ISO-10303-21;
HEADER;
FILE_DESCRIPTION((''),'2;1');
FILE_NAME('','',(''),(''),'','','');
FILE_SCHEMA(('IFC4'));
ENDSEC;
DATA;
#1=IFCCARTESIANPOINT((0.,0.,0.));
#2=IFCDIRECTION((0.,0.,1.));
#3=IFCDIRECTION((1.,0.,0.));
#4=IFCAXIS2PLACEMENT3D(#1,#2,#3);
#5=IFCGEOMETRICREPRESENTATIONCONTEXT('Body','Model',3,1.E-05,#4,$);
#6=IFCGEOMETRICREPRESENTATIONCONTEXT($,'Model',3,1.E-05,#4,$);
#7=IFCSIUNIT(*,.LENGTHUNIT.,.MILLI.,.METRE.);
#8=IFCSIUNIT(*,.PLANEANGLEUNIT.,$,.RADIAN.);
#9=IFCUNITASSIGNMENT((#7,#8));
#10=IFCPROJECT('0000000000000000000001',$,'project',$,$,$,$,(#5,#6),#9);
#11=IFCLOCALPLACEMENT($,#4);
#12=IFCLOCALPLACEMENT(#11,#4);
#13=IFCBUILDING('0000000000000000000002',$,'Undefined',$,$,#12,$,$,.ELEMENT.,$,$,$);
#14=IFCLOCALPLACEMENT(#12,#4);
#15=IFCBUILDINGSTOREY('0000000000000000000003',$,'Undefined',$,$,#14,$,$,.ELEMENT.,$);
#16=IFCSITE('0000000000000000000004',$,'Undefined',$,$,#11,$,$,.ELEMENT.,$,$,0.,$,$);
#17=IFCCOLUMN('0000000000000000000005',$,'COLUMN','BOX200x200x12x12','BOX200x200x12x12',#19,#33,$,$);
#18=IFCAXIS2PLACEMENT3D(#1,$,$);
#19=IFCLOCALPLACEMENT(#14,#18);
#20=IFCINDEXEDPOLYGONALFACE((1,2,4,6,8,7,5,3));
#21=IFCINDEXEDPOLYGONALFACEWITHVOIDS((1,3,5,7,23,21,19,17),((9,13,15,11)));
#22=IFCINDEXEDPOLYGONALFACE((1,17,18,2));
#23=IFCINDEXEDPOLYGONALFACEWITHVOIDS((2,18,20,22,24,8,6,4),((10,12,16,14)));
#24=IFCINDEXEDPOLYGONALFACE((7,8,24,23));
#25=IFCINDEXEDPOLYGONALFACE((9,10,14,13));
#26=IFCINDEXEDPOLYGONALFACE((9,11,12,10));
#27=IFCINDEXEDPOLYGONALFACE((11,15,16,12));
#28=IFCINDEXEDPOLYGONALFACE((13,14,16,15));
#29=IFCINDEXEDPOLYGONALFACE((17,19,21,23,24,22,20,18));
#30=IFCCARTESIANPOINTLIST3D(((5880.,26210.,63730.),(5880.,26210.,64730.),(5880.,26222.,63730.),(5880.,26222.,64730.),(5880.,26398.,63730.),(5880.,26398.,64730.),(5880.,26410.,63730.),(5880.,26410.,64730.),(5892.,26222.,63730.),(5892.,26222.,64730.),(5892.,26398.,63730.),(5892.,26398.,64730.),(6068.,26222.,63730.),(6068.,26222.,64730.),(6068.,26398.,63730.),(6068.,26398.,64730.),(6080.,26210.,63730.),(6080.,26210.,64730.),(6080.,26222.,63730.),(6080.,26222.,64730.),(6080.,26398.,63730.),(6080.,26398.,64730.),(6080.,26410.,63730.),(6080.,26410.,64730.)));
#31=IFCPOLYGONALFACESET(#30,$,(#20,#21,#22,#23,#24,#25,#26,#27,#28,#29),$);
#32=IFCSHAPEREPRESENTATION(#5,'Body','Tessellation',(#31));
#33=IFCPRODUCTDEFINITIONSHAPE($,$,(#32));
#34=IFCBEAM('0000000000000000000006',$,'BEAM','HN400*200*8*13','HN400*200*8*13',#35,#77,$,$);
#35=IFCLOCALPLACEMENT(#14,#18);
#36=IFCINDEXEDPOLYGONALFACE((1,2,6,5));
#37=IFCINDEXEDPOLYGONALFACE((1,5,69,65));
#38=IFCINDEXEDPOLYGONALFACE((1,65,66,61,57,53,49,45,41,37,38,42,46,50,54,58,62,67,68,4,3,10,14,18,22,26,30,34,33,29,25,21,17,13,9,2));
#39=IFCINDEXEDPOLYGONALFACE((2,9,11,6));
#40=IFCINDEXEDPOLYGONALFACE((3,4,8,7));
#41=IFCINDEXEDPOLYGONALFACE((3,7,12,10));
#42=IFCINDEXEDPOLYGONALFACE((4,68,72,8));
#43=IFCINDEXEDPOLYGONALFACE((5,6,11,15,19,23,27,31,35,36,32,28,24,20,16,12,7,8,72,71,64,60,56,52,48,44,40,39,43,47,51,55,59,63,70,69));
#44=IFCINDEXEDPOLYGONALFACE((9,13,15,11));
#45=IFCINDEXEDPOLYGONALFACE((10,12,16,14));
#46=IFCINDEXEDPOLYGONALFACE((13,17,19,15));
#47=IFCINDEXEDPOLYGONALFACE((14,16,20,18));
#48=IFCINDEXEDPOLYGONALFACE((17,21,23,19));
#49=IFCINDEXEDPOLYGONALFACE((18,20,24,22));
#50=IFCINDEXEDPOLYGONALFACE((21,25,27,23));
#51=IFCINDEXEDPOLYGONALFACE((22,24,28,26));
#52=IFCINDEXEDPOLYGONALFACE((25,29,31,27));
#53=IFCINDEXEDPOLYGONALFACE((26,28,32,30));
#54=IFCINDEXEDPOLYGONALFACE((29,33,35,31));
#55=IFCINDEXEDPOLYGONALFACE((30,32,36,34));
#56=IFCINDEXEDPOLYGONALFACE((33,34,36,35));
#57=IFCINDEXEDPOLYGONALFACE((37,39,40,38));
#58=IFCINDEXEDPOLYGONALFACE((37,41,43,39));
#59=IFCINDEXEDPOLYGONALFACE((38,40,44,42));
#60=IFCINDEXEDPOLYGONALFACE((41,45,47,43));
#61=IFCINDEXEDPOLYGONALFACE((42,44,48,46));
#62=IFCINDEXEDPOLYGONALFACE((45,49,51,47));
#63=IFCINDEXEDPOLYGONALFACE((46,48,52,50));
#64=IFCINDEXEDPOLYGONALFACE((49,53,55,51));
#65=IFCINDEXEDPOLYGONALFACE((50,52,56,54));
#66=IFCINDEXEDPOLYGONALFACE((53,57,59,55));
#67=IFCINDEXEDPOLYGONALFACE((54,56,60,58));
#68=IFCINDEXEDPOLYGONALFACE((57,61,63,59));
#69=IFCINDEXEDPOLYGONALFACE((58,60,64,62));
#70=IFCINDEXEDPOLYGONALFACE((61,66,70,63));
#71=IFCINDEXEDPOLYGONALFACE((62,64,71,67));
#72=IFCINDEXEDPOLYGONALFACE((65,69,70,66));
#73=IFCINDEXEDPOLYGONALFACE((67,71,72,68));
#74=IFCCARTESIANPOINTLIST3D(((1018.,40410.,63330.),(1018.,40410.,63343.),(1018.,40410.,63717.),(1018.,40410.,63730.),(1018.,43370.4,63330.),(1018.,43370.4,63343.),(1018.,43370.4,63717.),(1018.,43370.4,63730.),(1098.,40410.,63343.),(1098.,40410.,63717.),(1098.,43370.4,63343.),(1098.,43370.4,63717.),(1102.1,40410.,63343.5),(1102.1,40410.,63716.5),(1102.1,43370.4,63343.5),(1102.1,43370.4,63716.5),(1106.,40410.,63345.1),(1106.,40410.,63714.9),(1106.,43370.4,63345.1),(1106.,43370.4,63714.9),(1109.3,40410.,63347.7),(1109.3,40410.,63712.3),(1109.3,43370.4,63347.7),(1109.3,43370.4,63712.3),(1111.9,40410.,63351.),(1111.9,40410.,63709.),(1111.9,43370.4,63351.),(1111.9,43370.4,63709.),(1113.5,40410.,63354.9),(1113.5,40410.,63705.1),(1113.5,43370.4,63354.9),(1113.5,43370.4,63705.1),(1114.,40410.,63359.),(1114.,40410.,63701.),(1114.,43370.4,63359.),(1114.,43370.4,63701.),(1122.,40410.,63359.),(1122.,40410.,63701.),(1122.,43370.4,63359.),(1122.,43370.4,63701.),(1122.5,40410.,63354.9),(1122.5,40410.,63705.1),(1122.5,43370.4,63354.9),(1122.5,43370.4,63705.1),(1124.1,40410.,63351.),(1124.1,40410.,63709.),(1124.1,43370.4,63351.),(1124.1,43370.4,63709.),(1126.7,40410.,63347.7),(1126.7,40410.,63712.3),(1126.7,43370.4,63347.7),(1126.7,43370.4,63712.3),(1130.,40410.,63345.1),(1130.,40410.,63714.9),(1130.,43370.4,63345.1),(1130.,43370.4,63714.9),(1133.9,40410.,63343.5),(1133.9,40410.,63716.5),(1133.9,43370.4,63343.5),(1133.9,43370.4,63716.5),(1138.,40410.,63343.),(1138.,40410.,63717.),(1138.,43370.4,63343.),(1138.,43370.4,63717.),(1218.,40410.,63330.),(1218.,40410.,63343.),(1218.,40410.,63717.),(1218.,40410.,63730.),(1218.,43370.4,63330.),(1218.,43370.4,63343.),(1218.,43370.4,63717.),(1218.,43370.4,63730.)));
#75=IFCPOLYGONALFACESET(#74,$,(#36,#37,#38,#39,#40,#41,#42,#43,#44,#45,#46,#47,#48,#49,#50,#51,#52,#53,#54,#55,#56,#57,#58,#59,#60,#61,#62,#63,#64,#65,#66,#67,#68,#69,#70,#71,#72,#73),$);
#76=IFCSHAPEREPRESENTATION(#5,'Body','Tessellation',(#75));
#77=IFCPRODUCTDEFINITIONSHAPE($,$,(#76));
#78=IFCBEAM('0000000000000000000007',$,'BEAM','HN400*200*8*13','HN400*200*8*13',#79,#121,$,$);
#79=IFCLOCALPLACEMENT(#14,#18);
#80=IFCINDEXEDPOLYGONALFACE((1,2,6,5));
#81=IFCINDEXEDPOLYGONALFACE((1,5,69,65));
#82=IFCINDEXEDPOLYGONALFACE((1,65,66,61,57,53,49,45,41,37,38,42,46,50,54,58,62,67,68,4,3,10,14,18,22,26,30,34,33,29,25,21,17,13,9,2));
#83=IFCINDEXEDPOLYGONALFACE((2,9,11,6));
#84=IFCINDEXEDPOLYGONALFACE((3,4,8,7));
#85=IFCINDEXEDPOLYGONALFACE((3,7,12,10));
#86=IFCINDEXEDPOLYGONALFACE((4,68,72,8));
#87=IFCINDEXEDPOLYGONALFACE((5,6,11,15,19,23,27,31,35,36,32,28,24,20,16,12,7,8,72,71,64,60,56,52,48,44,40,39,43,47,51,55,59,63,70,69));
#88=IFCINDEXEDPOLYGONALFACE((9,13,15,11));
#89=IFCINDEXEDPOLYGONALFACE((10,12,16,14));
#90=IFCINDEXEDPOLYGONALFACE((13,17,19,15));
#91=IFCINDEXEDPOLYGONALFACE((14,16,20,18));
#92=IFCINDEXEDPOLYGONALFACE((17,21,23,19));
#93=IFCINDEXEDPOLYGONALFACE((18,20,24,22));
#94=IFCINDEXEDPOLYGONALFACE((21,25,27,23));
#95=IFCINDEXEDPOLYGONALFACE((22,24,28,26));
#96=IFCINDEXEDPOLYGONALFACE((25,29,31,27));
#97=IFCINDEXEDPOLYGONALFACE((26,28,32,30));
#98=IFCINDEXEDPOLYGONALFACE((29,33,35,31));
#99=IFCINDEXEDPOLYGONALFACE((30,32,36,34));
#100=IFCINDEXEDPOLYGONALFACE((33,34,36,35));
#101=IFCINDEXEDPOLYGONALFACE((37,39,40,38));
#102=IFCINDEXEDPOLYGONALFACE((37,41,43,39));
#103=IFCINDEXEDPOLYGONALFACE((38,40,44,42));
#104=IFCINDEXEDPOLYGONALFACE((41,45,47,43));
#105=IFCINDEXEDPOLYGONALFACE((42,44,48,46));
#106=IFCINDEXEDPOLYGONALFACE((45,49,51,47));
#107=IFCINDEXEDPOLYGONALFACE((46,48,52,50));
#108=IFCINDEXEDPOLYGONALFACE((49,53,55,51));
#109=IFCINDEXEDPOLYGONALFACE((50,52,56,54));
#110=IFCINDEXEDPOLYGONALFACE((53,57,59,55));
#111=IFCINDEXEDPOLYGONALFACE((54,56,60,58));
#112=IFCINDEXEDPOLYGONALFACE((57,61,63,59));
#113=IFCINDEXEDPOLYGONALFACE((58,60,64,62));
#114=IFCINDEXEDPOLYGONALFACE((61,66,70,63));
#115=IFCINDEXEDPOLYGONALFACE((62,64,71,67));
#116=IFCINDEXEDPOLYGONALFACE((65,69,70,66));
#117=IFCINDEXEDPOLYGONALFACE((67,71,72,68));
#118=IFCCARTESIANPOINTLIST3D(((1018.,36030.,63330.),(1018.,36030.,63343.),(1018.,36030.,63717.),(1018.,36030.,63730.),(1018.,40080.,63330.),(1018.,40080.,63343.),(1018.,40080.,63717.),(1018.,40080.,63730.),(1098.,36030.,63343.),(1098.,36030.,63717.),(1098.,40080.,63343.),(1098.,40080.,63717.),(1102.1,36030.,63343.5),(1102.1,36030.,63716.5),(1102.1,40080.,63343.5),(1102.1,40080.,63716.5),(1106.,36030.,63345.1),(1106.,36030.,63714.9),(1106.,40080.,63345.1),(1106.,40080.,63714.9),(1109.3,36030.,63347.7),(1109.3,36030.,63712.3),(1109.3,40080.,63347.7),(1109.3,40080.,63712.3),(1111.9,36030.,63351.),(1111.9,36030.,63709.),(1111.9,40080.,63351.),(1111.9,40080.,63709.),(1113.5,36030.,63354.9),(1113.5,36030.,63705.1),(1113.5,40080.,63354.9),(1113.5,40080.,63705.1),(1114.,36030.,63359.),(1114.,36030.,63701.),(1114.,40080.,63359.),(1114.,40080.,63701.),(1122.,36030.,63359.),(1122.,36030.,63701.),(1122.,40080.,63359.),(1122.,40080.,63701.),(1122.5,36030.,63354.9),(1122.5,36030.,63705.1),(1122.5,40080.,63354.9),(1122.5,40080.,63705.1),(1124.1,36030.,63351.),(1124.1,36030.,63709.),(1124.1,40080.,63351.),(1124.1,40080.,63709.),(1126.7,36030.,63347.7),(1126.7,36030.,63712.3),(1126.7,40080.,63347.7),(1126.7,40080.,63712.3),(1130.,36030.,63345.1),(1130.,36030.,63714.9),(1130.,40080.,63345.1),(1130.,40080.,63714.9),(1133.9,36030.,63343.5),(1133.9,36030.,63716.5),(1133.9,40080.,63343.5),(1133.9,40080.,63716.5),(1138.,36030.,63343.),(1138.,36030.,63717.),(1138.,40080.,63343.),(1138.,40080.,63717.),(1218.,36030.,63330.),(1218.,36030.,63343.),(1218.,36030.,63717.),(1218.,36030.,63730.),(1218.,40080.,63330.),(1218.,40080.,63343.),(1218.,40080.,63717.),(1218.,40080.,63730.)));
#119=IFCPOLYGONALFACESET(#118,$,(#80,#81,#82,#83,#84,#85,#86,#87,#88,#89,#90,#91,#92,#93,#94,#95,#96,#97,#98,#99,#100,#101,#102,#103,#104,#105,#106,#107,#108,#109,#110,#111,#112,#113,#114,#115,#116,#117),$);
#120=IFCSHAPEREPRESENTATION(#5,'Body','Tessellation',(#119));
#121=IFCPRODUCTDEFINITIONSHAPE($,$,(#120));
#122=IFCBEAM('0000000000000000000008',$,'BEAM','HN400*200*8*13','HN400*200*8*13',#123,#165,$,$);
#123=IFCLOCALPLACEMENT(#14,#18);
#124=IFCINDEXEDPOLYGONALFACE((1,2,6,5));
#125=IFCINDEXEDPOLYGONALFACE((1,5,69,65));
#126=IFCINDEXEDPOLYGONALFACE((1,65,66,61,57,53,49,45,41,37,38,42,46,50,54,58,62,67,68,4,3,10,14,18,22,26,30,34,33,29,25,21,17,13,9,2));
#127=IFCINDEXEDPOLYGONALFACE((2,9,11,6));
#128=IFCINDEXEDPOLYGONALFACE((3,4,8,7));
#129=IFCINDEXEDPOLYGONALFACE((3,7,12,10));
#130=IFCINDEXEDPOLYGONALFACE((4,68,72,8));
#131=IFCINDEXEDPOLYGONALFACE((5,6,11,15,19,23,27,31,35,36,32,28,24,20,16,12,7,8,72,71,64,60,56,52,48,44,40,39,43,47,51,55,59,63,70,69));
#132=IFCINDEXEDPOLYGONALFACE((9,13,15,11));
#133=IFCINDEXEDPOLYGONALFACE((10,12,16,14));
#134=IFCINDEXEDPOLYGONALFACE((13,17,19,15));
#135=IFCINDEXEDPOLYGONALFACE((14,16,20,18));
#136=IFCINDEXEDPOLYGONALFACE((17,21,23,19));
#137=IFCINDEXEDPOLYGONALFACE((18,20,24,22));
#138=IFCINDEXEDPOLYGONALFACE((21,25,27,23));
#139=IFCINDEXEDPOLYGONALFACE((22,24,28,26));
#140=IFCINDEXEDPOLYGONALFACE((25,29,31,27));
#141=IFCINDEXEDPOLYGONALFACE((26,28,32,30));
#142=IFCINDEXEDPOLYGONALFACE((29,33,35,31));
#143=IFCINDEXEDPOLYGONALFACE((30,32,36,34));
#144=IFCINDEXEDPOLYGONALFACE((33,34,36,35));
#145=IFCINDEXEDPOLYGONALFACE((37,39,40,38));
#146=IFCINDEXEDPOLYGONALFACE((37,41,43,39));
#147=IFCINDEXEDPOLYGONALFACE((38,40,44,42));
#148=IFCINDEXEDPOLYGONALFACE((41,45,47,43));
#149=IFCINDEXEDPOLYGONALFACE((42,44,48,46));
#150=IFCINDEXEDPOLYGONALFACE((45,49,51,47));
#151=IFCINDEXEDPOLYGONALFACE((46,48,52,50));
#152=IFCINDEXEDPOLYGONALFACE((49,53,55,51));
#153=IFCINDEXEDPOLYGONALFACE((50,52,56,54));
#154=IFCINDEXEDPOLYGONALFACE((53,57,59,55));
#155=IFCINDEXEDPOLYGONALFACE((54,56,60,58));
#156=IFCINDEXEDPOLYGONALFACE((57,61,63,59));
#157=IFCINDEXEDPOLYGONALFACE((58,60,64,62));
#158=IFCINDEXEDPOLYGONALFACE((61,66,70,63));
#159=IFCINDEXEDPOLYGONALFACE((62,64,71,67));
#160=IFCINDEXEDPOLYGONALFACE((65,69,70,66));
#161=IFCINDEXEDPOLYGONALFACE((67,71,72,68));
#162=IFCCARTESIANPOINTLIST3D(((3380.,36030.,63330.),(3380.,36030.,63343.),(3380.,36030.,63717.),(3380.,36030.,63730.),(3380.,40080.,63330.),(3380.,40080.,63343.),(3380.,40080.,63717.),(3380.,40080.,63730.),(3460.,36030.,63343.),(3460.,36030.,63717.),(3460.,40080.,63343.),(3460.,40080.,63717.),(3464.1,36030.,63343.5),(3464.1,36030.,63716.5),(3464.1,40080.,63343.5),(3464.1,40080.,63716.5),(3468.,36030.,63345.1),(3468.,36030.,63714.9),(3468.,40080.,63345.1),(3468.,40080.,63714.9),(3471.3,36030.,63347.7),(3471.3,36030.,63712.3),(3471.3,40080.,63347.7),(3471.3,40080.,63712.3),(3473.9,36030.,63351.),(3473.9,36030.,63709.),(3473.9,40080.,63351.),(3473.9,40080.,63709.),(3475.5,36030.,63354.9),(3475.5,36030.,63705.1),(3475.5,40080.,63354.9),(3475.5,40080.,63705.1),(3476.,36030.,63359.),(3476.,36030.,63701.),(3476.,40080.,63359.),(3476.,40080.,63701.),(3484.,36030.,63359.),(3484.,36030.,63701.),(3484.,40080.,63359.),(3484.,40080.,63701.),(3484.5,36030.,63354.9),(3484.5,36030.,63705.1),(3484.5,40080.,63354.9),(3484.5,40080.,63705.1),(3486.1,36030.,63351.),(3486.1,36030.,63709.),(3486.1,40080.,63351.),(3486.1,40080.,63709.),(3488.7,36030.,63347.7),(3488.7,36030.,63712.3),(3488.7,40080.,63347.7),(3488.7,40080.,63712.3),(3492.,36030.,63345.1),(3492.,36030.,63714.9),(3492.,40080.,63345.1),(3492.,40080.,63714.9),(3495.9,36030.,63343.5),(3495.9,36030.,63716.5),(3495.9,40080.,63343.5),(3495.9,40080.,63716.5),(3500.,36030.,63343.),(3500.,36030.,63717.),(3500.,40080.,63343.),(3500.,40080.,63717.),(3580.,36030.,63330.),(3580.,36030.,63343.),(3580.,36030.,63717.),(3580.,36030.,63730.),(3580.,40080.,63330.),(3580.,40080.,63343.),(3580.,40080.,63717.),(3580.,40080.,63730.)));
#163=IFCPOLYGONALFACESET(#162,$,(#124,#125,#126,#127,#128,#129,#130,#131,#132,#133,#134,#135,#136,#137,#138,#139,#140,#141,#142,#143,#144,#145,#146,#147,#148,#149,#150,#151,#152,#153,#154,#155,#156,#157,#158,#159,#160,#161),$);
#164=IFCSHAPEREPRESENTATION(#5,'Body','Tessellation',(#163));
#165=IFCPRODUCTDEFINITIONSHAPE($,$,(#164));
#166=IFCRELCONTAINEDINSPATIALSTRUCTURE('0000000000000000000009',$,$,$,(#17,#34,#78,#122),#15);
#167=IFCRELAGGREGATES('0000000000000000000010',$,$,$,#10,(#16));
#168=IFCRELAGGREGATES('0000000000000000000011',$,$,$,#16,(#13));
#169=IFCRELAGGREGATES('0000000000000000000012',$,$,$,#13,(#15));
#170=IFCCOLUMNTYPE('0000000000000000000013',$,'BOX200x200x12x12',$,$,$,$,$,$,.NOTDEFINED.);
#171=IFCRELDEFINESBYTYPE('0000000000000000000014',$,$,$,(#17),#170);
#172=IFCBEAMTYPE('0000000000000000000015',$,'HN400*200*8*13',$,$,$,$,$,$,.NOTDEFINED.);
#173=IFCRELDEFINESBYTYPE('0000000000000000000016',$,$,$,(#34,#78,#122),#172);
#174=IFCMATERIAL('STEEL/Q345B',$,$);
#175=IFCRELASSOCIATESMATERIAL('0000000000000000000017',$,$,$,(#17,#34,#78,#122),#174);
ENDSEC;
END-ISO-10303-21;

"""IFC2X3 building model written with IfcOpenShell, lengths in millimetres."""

from ifc_helpers import new_model, si_unit, frame, origin_with_axes, origin_2d_with_axis, place, context, project, spatial, polyline, i_section, outline, extrude, material, type_object, element, save


model = new_model("IFC2X3")

# Units and contexts
model_context_1 = context("Model", 3, precision=1e-05, world=origin_with_axes(), identifier="Body")
model_context_2 = context("Model", 3, precision=1e-05, world=origin_with_axes())
ifc_project = project(units=[si_unit("LENGTHUNIT", "METRE", prefix="MILLI"), si_unit("PLANEANGLEUNIT", "RADIAN")], contexts=[model_context_1, model_context_2])

# Site, building, storey
site_placement = place(None, origin_with_axes())
site = spatial("IfcSite", under=ifc_project, at=site_placement, Name="Undefined", CompositionType="ELEMENT", RefElevation=0.0)
building_placement = place(site_placement, origin_with_axes())
building = spatial("IfcBuilding", under=site, at=building_placement, Name="Undefined", CompositionType="ELEMENT")
storey_placement = place(building_placement, origin_with_axes())
storey = spatial("IfcBuildingStorey", under=building, at=storey_placement, Name="Undefined", CompositionType="ELEMENT")

# Column
ifc_material_1 = material(Name="STEEL/Q345B")
column_type = type_object("IfcColumnType", Name="BOX200x200x12x12", PredefinedType="NOTDEFINED")
column_placement = place(storey_placement, frame((5980.0, 26310.0, 63730.0), z_axis=(0.0, 0.0, 1.0), x_axis=(1.0, 0.0, 0.0)))
element("IfcColumn", 1, at=column_placement, inside=storey, type_object=column_type, material=ifc_material_1, Name="COLUMN", Description="BOX200x200x12x12", ObjectType="BOX200x200x12x12", context=model_context_1, shape_type="SweptSolid", body=[
    extrude(outline(polyline([(-100.0, -100.0), (100.0, -100.0), (100.0, -88.0), (100.0, 88.0), (100.0, 100.0), (-100.0, 100.0), (-100.0, 88.0), (-100.0, -88.0), (-100.0, -100.0)]), holes=[polyline([(-88.0, -88.0), (-88.0, 88.0), (88.0, 88.0), (88.0, -88.0), (-88.0, -88.0)])]), frame((0.0, 0.0, 1000.0), z_axis=(0.0, 0.0, -1.0), x_axis=(-1.0, 0.0, 0.0)), (0.0, 0.0, 1.0), 1000.0),
])

# Beams
beam_type_1 = type_object("IfcBeamType", Name="HN400*200*8*13", PredefinedType="NOTDEFINED")
beam_1_placement = place(storey_placement, frame((1118.0, 40245.0, 63530.0), z_axis=(0.0, 0.0, 1.0), x_axis=(0.0, 1.0, 0.0)))
element("IfcBeam", 2, at=beam_1_placement, inside=storey, type_object=beam_type_1, material=ifc_material_1, Name="BEAM", Description="HN400*200*8*13", ObjectType="HN400*200*8*13", context=model_context_1, shape_type="SweptSolid", body=[
    extrude(i_section(OverallWidth=200.0, OverallDepth=400.0, WebThickness=8.0, FlangeThickness=13.0, FilletRadius=16.0, at=origin_2d_with_axis()), frame((3125.4, 0.0, 0.0), z_axis=(-1.0, 0.0, 0.0), x_axis=(0.0, -1.0, 0.0)), (0.0, 0.0, 1.0), 2960.4),
])
beam_2_placement = place(storey_placement, frame((1118.0, 35680.0, 63530.0), z_axis=(0.0, 0.0, 1.0), x_axis=(0.0, 1.0, 0.0)))
element("IfcBeam", 3, at=beam_2_placement, inside=storey, type_object=beam_type_1, material=ifc_material_1, Name="BEAM", Description="HN400*200*8*13", ObjectType="HN400*200*8*13", context=model_context_1, shape_type="SweptSolid", body=[
    extrude(i_section(OverallWidth=200.0, OverallDepth=400.0, WebThickness=8.0, FlangeThickness=13.0, FilletRadius=16.0, at=origin_2d_with_axis()), frame((4400.0, 0.0, 0.0), z_axis=(-1.0, 0.0, 0.0), x_axis=(0.0, -1.0, 0.0)), (0.0, 0.0, 1.0), 4050.0),
])
beam_3_placement = place(storey_placement, frame((3480.0, 35616.0, 63530.0), z_axis=(0.0, 0.0, 1.0), x_axis=(0.0, 1.0, 0.0)))
element("IfcBeam", 4, at=beam_3_placement, inside=storey, type_object=beam_type_1, material=ifc_material_1, Name="BEAM", Description="HN400*200*8*13", ObjectType="HN400*200*8*13", context=model_context_1, shape_type="SweptSolid", body=[
    extrude(i_section(OverallWidth=200.0, OverallDepth=400.0, WebThickness=8.0, FlangeThickness=13.0, FilletRadius=16.0, at=origin_2d_with_axis()), frame((4464.0, 0.0, 0.0), z_axis=(-1.0, 0.0, 0.0), x_axis=(0.0, -1.0, 0.0)), (0.0, 0.0, 1.0), 4050.0),
])

save(model, "model.ifc")
